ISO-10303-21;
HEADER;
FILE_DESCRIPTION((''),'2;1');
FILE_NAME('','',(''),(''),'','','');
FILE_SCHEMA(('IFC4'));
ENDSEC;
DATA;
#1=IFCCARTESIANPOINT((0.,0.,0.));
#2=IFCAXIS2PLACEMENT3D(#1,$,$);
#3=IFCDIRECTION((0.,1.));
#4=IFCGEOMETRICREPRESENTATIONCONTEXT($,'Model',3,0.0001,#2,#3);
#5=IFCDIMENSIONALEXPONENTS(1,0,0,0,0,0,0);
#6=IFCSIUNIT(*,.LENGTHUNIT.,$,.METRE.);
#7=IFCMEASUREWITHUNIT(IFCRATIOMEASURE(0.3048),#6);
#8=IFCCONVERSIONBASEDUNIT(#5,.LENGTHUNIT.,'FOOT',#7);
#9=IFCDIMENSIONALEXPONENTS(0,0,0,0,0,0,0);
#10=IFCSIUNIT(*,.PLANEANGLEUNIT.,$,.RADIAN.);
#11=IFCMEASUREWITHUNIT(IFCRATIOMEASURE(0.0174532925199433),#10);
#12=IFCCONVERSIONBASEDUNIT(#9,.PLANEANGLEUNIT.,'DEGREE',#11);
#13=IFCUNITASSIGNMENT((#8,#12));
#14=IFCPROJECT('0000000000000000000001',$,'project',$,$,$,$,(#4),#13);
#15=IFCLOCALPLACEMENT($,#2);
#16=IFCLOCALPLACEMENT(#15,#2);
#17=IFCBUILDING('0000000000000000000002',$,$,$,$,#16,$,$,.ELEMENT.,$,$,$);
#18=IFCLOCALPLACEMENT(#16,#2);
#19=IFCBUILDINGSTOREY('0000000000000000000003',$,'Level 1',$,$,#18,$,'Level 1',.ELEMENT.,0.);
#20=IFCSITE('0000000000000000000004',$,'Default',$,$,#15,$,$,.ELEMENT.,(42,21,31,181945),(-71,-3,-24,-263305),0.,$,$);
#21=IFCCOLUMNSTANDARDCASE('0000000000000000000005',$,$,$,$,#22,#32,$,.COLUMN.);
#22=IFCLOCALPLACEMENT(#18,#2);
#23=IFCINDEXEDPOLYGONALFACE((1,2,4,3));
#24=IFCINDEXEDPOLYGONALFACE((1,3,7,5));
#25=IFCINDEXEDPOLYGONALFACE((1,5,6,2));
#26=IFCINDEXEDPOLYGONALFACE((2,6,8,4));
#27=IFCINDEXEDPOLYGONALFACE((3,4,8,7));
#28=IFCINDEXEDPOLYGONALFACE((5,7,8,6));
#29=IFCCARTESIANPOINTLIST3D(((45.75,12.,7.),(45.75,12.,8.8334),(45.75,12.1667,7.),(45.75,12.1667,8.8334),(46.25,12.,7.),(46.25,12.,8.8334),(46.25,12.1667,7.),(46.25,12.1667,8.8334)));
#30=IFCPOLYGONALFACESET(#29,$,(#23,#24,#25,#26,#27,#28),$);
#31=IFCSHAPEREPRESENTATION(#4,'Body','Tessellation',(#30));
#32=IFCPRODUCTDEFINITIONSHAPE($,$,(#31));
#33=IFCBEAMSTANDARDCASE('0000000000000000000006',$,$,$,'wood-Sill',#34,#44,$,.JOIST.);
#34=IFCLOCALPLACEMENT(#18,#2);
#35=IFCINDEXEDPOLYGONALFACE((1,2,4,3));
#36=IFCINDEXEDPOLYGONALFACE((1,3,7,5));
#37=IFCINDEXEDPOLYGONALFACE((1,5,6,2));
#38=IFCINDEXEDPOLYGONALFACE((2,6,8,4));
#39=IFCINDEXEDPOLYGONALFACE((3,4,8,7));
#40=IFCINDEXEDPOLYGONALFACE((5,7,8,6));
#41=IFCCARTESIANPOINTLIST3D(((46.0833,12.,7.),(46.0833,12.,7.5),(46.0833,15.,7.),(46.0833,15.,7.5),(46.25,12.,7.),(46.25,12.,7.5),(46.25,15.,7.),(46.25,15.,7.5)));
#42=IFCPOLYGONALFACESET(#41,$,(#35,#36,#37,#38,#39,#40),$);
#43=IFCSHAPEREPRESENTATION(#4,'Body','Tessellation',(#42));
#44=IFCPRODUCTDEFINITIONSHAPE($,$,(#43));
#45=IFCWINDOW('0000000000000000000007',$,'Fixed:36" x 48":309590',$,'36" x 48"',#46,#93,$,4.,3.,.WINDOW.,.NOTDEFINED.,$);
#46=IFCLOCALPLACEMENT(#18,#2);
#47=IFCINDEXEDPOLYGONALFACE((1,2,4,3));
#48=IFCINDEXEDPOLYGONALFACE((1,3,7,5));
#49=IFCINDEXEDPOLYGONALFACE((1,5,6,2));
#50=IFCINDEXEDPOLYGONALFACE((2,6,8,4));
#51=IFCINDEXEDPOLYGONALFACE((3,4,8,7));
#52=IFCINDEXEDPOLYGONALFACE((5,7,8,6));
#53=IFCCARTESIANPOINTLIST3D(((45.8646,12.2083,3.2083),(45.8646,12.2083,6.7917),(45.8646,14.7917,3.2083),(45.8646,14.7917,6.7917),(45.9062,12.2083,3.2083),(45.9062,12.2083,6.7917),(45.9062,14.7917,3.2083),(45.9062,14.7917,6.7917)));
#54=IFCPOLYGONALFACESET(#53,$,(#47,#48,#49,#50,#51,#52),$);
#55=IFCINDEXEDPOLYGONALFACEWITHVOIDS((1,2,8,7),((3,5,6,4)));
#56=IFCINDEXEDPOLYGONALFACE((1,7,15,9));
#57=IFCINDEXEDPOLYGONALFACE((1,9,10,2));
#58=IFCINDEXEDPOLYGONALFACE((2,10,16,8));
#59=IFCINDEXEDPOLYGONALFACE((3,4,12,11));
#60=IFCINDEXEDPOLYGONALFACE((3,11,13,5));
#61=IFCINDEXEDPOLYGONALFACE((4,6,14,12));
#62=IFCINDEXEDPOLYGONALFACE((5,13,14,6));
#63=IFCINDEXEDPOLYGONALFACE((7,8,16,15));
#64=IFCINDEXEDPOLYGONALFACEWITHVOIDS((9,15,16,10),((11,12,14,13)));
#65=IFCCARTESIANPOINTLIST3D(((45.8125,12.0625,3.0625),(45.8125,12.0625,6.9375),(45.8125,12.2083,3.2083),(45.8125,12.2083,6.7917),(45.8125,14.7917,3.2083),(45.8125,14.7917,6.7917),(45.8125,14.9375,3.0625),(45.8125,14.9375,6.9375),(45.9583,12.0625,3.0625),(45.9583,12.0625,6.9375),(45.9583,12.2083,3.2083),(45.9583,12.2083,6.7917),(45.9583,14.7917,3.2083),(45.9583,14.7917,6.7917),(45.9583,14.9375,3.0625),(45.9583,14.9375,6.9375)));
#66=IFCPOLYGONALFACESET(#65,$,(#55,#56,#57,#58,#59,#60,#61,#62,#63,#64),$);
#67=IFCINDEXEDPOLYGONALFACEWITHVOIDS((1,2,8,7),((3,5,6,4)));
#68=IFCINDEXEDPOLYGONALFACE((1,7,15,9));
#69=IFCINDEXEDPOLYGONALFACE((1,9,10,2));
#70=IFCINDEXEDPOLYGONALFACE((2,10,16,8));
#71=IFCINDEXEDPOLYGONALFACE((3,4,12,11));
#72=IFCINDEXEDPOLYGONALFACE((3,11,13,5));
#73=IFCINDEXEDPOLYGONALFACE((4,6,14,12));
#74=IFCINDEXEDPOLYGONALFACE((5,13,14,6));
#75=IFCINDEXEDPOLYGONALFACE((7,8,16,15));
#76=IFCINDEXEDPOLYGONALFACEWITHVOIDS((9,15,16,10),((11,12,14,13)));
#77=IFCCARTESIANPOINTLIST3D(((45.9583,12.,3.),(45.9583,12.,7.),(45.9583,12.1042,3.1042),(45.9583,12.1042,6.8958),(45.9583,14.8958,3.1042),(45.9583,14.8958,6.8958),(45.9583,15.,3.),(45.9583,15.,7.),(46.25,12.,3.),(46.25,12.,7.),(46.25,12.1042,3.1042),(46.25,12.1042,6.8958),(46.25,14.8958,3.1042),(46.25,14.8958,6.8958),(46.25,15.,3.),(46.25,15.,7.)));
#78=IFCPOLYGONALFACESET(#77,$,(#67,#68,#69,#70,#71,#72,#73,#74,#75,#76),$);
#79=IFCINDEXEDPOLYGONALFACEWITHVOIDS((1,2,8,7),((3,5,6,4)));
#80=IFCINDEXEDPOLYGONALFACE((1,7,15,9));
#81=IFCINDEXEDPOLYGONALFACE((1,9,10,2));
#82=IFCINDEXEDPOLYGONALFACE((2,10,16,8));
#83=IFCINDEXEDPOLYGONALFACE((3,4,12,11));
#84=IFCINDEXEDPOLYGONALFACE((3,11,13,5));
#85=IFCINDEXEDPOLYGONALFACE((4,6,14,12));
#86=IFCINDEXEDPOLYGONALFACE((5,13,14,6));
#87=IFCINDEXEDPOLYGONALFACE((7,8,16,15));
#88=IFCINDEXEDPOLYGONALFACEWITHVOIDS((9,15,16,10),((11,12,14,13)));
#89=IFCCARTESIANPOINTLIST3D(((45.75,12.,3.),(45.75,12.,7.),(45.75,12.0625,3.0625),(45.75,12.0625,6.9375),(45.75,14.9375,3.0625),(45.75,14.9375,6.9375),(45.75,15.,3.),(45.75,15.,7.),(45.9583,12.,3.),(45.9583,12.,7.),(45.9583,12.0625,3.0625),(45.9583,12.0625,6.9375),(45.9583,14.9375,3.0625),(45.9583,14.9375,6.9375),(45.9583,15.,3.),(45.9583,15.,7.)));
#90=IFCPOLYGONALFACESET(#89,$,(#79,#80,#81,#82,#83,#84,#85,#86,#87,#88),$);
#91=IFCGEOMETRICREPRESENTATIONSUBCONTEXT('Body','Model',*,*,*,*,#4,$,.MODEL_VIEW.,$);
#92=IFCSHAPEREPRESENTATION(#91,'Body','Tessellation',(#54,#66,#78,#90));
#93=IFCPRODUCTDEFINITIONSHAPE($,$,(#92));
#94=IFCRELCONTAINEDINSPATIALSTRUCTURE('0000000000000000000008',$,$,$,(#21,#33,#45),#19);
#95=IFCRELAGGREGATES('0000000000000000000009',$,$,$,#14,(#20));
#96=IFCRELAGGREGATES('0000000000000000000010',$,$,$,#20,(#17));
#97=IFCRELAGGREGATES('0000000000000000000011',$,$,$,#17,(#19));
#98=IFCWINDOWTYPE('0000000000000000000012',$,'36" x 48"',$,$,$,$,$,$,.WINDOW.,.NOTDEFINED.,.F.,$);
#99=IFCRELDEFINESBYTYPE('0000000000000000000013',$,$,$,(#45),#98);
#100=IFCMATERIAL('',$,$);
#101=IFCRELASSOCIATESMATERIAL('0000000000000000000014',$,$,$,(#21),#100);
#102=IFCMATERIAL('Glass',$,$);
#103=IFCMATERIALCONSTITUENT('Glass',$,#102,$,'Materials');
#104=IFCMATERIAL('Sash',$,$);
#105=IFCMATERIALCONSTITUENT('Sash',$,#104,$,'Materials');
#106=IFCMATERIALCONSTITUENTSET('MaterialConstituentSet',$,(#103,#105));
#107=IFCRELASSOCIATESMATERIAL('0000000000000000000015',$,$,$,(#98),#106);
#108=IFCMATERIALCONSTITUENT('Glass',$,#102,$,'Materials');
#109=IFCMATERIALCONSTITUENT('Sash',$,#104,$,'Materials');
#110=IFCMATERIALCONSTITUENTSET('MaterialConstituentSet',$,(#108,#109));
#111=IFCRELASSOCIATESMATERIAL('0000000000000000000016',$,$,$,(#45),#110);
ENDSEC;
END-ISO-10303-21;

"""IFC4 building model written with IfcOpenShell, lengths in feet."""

from ifc_helpers import new_model, entity, si_unit, converted_unit, direction, frame, frame_2d, origin, origin_with_axes, place, context, subcontext, project, spatial, polyline, rectangle, outline, extrude, source, transform, mapped, material, constituent, constituent_set, type_object, type_shapes, element, save


model = new_model("IFC4")

# Units and contexts
model_context = context("Model", 3, precision=0.0001, world=origin(), true_north=direction((0.0, 1.0)))
body_context = subcontext(model_context, "Body", "Model", "MODEL_VIEW")
ifc_project = project(units=[converted_unit("LENGTHUNIT", "FOOT", entity("IfcRatioMeasure", 0.3048), si_unit("LENGTHUNIT", "METRE"), dimensions=[1, 0, 0, 0, 0, 0, 0]), converted_unit("PLANEANGLEUNIT", "DEGREE", entity("IfcRatioMeasure", 0.0174532925199433), si_unit("PLANEANGLEUNIT", "RADIAN"), dimensions=[0, 0, 0, 0, 0, 0, 0])], contexts=[model_context])

# Site, building, storey
site_placement = place(None, origin())
site = spatial("IfcSite", under=ifc_project, at=site_placement, Name="Default", CompositionType="ELEMENT", RefLatitude=(42, 21, 31, 181945), RefLongitude=(-71, -3, -24, -263305), RefElevation=0.0)
building_placement = place(site_placement, origin())
building = spatial("IfcBuilding", under=site, at=building_placement, CompositionType="ELEMENT")
storey_placement = place(building_placement, origin())
storey = spatial("IfcBuildingStorey", under=building, at=storey_placement, Name="Level 1", LongName="Level 1", CompositionType="ELEMENT", Elevation=0.0)

# Column
placement_1 = place(storey_placement, frame((46.0, 46.25, 0.0), z_axis=(0.0, 0.0, 1.0), x_axis=(0.0, -1.0, 0.0)))
ifc_material_1 = material(Name="")
for number, where, z_axis, x_axis in (
    (1, (34.1667, 0.0, 7.0), (0.0, 0.0, 1.0), (1.0, 0.0, 0.0)),
):
    element("IfcColumnStandardCase", number, at=place(placement_1, frame(where, z_axis=z_axis, x_axis=x_axis)), inside=storey, material=ifc_material_1, PredefinedType="COLUMN", context=model_context, shape_type="SweptSolid", body=[
        extrude(rectangle(XDim=0.1667, YDim=0.5), origin(), (0.0, 0.0, 1.0), 1.8334),
    ])

# Beam
for number, where, z_axis, x_axis in (
    (2, (31.25, 0.1667, 7.25), (1.0, 0.0, 0.0), (0.0, 0.0, 1.0)),
):
    element("IfcBeamStandardCase", number, at=place(placement_1, frame(where, z_axis=z_axis, x_axis=x_axis)), inside=storey, ObjectType="wood-Sill", PredefinedType="JOIST", context=model_context, shape_type="SweptSolid", body=[
        extrude(rectangle(XDim=0.5, YDim=0.1667), origin_with_axes(), (0.0, 0.0, 1.0), 3.0),
    ])

# Window
ifc_material_2 = material(Name="Glass")
ifc_constituent_1 = constituent(ifc_material_2, Name="Glass", Category="Materials")
ifc_material_3 = material(Name="Sash")
ifc_constituent_2 = constituent(ifc_material_3, Name="Sash", Category="Materials")
ifc_constituent_set_1 = constituent_set(constituents=[ifc_constituent_1, ifc_constituent_2], Name="MaterialConstituentSet")
ifc_constituent_3 = constituent(ifc_material_2, Name="Glass", Category="Materials")
ifc_constituent_4 = constituent(ifc_material_3, Name="Sash", Category="Materials")
ifc_constituent_set_2 = constituent_set(constituents=[ifc_constituent_3, ifc_constituent_4], Name="MaterialConstituentSet")
window_type = type_object("IfcWindowType", Name="36\" x 48\"", ParameterTakesPrecedence=False, PartitioningType="NOTDEFINED", PredefinedType="WINDOW", material=ifc_constituent_set_2)
shared_shape = source(origin(), body_context, "Body", "SweptSolid", [
    extrude(rectangle(XDim=0.0417, YDim=2.5833, at=frame_2d((0.0, 0.0), x_axis=(1.0, 0.0))), frame((1.5, 0.3646, 0.2083), z_axis=(0.0, 0.0, 1.0), x_axis=(0.0, 1.0, 0.0)), (0.0, 0.0, 1.0), 3.5833),
    extrude(outline(polyline([(-1.4375, -1.9375), (1.4375, -1.9375), (1.4375, 1.9375), (-1.4375, 1.9375), (-1.4375, -1.9375)]), holes=[polyline([(-1.2917, -1.7917), (-1.2917, 1.7917), (1.2917, 1.7917), (1.2917, -1.7917), (-1.2917, -1.7917)])]), frame((1.5, 0.2917, 2.0), z_axis=(0.0, 1.0, 0.0), x_axis=(1.0, 0.0, 0.0)), (0.0, 0.0, 1.0), 0.1458),
    extrude(outline(polyline([(-1.5, -2.0), (1.5, -2.0), (1.5, 2.0), (-1.5, 2.0), (-1.5, -2.0)]), holes=[polyline([(-1.3958, -1.8958), (-1.3958, 1.8958), (1.3958, 1.8958), (1.3958, -1.8958), (-1.3958, -1.8958)])]), frame((1.5, 0.0, 2.0), z_axis=(0.0, 1.0, 0.0), x_axis=(1.0, 0.0, 0.0)), (0.0, 0.0, 1.0), 0.2917),
    extrude(outline(polyline([(-2.0, -1.5), (2.0, -1.5), (2.0, 1.5), (-2.0, 1.5), (-2.0, -1.5)]), holes=[polyline([(-1.9375, -1.4375), (-1.9375, 1.4375), (1.9375, 1.4375), (1.9375, -1.4375), (-1.9375, -1.4375)])]), frame((1.5, 0.2917, 2.0), z_axis=(0.0, 1.0, 0.0), x_axis=(0.0, 0.0, -1.0)), (0.0, 0.0, 1.0), 0.2083),
])
type_shapes(window_type, [shared_shape])
placement_2 = place(placement_1, frame((34.25, 0.25, 3.0)))
window_placement = place(placement_2, frame((0.0, 0.0, 0.0), z_axis=(0.0, 0.0, 1.0), x_axis=(-1.0, 0.0, 0.0)))
element("IfcWindow", 3, at=window_placement, inside=storey, type_object=window_type, material=ifc_constituent_set_1, Name="Fixed:36\" x 48\":309590", ObjectType="36\" x 48\"", OverallHeight=4.0, OverallWidth=3.0, PartitioningType="NOTDEFINED", PredefinedType="WINDOW", context=body_context, shape_type="MappedRepresentation", body=[
    mapped(shared_shape, transform((0.0, 0.0, 0.0), scale=1.0)),
])

save(model, "model.ifc")
